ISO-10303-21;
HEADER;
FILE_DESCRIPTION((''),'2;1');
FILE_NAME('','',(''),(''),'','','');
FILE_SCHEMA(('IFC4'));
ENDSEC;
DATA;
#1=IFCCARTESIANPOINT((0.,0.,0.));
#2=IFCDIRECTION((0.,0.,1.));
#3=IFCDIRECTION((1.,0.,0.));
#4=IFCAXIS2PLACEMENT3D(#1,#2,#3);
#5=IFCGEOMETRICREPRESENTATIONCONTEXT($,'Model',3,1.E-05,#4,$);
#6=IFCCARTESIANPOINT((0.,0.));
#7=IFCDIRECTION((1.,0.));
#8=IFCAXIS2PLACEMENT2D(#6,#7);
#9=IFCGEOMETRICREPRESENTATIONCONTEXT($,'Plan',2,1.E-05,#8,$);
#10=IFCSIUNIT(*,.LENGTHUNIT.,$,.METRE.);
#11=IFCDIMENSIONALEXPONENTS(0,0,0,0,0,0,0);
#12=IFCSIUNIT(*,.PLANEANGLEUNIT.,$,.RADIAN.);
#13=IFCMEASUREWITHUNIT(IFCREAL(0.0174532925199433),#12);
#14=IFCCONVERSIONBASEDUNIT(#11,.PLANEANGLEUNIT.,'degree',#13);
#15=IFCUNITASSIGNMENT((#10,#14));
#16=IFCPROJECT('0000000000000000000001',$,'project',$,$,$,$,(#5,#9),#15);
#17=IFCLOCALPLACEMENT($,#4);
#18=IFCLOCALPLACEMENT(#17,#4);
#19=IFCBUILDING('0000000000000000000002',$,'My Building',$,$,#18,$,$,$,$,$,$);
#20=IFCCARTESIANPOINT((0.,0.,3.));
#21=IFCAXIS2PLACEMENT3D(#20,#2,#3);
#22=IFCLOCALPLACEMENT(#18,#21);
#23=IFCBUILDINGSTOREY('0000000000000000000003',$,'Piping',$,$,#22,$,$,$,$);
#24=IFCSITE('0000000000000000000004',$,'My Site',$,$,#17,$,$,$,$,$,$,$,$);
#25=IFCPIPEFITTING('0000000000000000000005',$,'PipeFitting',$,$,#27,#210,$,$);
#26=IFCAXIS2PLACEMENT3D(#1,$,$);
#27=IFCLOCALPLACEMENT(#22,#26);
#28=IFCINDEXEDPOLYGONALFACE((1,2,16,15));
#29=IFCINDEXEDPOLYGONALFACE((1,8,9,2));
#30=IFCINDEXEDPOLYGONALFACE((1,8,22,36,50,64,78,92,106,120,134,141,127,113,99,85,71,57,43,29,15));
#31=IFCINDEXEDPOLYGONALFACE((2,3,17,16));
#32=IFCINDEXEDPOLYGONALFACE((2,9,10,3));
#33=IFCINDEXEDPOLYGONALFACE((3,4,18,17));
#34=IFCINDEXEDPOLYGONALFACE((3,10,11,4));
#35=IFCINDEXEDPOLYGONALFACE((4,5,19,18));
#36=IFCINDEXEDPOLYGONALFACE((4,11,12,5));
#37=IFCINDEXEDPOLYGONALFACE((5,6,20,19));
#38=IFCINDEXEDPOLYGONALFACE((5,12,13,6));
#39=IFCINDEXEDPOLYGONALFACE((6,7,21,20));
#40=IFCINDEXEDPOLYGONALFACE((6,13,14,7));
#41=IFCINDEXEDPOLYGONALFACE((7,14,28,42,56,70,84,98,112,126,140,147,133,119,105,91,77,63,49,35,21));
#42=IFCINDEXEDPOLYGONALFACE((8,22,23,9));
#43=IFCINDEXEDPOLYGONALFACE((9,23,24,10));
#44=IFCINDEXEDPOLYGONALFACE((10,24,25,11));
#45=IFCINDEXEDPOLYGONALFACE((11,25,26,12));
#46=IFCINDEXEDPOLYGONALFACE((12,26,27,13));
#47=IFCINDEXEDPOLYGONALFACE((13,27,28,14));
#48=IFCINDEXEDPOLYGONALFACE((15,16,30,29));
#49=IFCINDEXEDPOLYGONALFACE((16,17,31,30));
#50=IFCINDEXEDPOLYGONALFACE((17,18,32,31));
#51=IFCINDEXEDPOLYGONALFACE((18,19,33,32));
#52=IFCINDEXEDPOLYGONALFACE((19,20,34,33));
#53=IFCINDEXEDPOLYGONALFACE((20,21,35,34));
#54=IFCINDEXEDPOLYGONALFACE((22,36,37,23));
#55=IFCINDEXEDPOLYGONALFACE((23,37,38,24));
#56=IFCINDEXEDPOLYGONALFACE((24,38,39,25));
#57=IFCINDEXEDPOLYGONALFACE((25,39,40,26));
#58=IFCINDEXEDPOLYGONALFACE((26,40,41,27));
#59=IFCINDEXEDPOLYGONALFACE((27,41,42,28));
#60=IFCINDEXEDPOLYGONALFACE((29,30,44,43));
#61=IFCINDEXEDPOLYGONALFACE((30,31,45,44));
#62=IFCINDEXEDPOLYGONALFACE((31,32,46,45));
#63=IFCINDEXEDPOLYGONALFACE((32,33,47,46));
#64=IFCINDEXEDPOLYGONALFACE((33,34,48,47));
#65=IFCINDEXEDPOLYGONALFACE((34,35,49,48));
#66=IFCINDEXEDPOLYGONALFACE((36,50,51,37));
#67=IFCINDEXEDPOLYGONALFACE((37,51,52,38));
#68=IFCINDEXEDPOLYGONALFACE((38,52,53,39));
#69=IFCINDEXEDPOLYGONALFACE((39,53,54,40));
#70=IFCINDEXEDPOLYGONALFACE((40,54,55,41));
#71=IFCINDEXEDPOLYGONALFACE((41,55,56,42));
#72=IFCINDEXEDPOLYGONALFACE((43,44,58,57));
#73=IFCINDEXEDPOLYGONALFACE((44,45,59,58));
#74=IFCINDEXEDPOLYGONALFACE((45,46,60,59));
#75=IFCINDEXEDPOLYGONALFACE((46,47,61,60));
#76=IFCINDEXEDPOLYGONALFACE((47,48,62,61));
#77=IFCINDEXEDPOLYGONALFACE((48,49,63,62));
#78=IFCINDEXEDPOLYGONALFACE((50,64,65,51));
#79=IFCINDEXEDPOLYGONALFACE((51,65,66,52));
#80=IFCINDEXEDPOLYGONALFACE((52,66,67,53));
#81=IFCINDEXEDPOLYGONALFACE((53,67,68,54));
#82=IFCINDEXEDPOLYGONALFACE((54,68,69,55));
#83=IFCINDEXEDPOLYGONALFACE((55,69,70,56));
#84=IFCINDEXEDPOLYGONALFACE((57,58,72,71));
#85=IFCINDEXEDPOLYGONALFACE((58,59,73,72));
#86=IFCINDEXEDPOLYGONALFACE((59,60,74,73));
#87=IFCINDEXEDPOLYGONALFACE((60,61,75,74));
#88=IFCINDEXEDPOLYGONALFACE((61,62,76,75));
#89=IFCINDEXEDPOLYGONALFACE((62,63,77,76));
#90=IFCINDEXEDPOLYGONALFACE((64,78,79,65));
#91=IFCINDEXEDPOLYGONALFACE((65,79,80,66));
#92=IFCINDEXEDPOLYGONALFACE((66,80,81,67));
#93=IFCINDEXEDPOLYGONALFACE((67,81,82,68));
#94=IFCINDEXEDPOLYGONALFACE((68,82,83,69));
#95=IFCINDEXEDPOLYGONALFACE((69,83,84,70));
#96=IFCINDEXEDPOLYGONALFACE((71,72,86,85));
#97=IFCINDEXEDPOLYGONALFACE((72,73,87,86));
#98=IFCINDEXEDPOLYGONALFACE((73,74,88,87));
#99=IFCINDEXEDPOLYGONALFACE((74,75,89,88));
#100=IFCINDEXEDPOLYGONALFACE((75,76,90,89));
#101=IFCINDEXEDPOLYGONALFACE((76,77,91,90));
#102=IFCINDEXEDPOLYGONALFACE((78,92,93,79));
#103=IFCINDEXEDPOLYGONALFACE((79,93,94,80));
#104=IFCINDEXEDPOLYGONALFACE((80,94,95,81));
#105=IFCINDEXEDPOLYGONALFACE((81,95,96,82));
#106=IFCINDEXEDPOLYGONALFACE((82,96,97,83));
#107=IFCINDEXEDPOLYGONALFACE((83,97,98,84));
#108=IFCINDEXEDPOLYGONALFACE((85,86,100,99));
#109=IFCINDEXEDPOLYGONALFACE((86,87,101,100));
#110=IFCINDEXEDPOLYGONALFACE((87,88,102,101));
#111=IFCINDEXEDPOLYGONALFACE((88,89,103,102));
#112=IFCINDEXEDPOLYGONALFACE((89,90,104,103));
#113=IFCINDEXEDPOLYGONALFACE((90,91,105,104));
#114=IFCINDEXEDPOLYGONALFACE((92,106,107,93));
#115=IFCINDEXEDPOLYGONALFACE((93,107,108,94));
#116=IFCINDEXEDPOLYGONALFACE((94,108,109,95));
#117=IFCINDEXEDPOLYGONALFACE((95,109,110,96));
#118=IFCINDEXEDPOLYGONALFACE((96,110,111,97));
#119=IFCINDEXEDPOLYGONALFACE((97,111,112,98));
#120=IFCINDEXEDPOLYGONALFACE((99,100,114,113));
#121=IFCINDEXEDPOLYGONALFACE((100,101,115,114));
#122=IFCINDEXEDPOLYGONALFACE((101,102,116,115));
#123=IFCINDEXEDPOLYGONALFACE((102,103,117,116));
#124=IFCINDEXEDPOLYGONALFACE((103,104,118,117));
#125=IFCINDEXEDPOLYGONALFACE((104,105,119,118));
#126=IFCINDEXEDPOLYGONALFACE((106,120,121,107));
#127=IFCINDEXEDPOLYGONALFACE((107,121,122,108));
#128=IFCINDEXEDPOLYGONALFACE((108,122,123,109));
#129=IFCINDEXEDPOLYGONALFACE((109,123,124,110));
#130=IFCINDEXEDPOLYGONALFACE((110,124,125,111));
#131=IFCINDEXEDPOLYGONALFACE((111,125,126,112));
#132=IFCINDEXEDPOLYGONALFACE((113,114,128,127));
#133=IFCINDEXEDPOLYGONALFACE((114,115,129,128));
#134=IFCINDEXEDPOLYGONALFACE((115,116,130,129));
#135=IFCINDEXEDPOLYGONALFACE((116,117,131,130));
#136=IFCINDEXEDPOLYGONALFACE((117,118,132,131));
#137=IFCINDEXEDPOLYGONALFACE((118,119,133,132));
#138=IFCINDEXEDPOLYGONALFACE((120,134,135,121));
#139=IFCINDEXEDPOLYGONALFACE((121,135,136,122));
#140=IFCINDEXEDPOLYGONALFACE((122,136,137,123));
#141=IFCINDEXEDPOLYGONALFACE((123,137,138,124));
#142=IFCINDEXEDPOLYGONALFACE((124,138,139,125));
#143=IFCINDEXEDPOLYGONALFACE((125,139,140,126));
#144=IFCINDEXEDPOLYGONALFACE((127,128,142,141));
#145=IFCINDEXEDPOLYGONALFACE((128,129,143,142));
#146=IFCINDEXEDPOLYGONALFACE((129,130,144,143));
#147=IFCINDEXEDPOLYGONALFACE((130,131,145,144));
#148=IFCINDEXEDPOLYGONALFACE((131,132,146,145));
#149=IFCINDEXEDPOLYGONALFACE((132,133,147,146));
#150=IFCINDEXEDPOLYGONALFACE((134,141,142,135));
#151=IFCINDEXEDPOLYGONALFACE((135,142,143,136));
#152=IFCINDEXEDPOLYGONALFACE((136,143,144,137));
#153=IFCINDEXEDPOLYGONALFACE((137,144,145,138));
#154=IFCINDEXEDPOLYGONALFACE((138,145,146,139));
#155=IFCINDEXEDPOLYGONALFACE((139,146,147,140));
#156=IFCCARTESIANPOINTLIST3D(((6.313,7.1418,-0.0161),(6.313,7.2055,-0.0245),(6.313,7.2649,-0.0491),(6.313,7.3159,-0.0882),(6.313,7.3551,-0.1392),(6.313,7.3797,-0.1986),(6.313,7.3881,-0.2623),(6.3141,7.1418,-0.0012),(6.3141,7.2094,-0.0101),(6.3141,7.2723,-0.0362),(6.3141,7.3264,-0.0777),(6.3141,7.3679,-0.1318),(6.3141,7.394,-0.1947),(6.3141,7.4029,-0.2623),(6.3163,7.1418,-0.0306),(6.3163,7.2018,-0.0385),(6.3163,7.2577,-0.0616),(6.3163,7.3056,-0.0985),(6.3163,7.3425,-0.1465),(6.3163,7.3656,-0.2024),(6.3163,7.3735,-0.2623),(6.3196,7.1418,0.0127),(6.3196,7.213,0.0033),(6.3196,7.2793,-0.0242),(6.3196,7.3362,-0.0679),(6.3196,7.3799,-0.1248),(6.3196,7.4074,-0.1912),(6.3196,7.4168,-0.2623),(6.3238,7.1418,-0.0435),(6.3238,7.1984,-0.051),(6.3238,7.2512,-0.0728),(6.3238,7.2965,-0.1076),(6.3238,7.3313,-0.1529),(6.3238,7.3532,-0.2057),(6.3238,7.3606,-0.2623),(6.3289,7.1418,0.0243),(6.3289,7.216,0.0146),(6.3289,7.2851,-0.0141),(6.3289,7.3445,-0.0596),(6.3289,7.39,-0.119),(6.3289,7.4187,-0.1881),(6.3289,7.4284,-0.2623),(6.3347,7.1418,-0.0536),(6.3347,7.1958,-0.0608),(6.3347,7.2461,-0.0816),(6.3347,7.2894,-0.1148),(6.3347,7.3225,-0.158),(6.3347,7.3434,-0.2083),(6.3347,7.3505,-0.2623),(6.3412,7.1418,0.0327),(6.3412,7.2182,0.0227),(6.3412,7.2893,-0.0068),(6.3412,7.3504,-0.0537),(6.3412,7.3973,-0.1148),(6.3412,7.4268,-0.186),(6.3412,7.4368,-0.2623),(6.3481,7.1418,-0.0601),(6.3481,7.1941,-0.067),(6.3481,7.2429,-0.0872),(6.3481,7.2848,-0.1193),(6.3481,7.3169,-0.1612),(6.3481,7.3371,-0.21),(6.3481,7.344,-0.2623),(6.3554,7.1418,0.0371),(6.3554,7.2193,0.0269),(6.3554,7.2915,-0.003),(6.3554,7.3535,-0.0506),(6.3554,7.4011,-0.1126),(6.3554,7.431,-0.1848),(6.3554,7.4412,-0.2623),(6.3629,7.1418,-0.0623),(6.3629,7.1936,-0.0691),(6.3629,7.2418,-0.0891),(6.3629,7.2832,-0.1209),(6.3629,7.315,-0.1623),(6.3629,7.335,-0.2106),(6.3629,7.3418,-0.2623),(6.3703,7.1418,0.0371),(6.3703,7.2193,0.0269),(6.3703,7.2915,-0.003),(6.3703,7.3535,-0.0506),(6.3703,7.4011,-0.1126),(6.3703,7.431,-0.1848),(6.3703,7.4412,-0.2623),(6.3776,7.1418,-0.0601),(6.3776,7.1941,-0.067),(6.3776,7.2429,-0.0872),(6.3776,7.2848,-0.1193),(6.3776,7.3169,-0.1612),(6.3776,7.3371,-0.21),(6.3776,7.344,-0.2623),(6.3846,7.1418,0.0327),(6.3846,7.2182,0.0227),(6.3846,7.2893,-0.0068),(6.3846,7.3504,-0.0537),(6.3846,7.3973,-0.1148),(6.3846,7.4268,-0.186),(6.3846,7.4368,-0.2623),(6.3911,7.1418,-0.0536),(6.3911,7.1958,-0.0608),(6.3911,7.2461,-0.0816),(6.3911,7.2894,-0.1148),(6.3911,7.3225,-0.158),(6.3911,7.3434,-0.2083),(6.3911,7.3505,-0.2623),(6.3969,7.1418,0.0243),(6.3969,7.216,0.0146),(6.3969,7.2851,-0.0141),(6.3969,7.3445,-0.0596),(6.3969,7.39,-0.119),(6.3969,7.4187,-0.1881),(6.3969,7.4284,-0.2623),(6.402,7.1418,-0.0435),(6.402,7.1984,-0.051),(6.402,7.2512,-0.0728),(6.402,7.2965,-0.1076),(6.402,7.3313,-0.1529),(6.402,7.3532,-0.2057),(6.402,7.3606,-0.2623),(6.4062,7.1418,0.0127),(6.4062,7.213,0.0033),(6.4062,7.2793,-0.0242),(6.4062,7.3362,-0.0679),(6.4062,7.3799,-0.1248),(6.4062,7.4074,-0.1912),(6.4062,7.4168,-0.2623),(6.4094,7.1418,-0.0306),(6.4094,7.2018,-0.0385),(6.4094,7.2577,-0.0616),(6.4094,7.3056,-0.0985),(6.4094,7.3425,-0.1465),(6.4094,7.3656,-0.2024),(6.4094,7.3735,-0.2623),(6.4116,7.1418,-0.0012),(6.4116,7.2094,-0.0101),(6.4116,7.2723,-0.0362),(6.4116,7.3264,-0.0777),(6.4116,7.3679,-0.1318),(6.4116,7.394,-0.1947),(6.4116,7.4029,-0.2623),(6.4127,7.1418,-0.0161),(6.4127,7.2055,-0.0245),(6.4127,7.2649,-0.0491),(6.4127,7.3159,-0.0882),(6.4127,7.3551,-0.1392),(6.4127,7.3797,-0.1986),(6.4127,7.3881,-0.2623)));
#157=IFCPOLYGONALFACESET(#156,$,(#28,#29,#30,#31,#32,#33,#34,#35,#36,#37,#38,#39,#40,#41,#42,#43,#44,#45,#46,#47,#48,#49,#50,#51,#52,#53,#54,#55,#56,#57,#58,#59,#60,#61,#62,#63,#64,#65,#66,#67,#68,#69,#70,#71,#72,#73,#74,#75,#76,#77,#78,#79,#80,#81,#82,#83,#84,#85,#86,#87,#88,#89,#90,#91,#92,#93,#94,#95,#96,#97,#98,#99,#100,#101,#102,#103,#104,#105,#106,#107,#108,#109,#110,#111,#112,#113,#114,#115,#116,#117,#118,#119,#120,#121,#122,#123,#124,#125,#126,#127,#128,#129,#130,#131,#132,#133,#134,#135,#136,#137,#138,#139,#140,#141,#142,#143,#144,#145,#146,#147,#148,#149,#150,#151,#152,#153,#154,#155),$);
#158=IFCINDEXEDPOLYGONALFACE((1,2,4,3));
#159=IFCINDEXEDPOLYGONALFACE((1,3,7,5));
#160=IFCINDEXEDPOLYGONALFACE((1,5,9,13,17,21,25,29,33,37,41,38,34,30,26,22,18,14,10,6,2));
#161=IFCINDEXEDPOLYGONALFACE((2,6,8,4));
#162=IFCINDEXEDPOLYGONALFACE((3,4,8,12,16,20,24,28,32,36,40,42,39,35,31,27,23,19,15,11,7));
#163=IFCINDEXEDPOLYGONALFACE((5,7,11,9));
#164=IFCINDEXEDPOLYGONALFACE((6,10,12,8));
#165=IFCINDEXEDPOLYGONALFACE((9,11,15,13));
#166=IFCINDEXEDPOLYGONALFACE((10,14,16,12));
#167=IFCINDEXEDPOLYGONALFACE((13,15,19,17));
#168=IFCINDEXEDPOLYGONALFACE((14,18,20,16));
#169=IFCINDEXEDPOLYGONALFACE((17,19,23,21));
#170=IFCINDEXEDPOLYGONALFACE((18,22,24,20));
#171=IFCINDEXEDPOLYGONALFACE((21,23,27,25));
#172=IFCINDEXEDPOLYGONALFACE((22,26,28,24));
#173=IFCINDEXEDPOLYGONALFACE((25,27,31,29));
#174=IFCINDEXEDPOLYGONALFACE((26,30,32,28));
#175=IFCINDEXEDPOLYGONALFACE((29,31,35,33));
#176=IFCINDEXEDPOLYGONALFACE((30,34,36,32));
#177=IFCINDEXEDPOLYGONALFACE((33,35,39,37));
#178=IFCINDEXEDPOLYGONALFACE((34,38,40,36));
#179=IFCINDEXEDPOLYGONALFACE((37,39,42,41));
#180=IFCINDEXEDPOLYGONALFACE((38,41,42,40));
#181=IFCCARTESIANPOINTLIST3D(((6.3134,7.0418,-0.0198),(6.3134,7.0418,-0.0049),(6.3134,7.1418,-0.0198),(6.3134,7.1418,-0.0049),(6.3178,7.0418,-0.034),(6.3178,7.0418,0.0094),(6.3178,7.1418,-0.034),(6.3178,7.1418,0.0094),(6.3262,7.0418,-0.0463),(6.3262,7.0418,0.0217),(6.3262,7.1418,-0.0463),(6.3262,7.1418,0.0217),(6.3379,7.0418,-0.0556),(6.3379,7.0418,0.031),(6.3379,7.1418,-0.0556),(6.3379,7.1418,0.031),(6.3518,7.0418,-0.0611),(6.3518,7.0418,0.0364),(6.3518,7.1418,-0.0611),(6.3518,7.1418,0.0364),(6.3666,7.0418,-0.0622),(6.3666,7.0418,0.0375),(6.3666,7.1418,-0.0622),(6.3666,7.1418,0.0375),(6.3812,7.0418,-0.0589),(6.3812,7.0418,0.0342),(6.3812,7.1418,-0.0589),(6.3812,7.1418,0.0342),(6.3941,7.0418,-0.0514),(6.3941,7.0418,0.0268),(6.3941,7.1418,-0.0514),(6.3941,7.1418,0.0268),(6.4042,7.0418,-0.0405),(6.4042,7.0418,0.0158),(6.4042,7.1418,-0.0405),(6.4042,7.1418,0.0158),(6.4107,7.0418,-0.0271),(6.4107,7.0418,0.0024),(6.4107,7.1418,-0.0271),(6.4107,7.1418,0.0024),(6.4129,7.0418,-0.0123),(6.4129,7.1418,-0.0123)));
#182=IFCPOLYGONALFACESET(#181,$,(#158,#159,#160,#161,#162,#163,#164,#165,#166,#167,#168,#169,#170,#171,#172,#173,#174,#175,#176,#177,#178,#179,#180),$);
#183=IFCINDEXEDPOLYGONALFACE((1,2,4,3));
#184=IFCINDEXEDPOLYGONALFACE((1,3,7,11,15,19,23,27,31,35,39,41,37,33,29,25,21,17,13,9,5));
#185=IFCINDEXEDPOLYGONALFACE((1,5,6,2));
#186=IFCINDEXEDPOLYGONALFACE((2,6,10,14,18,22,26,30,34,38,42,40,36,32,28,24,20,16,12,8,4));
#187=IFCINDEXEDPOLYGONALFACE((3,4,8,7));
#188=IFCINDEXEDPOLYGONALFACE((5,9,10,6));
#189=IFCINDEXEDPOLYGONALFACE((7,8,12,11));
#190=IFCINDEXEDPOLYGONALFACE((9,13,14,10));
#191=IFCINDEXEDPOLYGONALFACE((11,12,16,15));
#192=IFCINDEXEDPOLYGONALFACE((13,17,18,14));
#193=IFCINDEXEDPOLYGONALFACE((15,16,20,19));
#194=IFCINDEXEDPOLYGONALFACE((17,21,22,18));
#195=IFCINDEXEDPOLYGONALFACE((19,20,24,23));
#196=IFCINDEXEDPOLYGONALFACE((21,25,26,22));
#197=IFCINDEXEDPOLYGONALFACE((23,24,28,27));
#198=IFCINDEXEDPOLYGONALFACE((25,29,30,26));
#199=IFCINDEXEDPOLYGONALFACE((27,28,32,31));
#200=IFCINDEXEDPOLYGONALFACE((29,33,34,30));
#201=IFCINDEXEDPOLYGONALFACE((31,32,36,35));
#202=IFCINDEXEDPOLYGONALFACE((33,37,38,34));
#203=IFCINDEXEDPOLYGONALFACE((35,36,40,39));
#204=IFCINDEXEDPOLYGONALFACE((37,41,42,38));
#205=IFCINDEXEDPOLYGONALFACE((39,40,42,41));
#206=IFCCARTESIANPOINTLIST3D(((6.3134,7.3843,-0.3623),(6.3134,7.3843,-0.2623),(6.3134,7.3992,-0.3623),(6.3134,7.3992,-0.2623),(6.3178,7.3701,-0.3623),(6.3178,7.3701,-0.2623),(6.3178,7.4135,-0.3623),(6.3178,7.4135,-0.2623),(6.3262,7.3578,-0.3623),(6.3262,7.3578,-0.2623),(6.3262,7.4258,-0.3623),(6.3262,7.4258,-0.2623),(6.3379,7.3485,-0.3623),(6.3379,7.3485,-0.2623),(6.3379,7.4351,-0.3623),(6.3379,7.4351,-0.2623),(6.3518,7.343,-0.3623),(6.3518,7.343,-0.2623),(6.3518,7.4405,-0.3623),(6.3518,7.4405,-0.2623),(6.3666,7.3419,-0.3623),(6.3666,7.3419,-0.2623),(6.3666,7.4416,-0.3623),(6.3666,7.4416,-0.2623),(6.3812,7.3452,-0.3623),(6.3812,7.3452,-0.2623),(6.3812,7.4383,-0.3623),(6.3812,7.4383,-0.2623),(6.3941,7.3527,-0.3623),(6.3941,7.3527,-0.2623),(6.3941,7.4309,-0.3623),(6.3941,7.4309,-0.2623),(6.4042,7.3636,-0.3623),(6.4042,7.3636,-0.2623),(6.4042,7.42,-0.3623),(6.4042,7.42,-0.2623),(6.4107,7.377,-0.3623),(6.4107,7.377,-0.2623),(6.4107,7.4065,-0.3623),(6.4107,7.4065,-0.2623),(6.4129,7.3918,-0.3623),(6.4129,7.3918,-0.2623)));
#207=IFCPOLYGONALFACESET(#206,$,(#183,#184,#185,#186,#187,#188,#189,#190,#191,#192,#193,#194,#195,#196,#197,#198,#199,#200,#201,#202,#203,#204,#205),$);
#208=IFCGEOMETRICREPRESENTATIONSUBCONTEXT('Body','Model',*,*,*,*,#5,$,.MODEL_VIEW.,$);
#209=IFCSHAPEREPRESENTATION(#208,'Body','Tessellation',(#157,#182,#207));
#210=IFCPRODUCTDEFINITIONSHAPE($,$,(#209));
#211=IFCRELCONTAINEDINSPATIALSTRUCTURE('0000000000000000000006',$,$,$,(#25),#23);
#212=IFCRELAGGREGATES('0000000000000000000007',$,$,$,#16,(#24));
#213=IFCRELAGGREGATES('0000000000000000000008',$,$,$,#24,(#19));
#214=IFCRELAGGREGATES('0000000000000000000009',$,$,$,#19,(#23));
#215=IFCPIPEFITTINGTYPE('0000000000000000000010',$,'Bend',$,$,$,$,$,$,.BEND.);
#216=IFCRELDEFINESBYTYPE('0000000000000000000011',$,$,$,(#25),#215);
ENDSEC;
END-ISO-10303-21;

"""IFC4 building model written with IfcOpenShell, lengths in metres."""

from ifc_helpers import new_model, entity, si_unit, converted_unit, frame, origin_with_axes, origin_2d_with_axis, place, context, subcontext, project, spatial, circle, extrude, source, transform, mapped, type_object, type_shapes, element, save


model = new_model("IFC4")

# Units and contexts
model_context = context("Model", 3, precision=1e-05, world=origin_with_axes())
plan_context = context("Plan", 2, precision=1e-05, world=origin_2d_with_axis())
body_context = subcontext(model_context, "Body", "Model", "MODEL_VIEW")
ifc_project = project(units=[si_unit("LENGTHUNIT", "METRE"), converted_unit("PLANEANGLEUNIT", "degree", entity("IfcReal", 0.0174532925199433), si_unit("PLANEANGLEUNIT", "RADIAN"), dimensions=[0, 0, 0, 0, 0, 0, 0])], contexts=[model_context, plan_context])

# Site, building, storey
site_placement = place(None, origin_with_axes())
site = spatial("IfcSite", under=ifc_project, at=site_placement, Name="My Site")
building_placement = place(site_placement, origin_with_axes())
building = spatial("IfcBuilding", under=site, at=building_placement, Name="My Building")
storey_placement = place(building_placement, frame((0.0, 0.0, 3.0), z_axis=(0.0, 0.0, 1.0), x_axis=(1.0, 0.0, 0.0)))
storey = spatial("IfcBuildingStorey", under=building, at=storey_placement, Name="Piping")

# Pipe fitting
pipe_fitting_type = type_object("IfcPipeFittingType", Name="Bend", PredefinedType="BEND")
shared_shape = source(origin_with_axes(), body_context, "Body", "SolidModel", [
    entity("IfcSweptDiskSolid", entity("IfcIndexedPolyCurve", entity("IfcCartesianPointList3D", [[0.0, 0.0, -0.1], [0.0, -0.0732, -0.2768], [0.0, -0.25, -0.35]]), [entity("IfcArcIndex", [1, 2, 3])]), 0.05),
    extrude(circle(Radius=0.05), origin_with_axes(), (0.0, 0.0, -1.0), 0.1),
    extrude(circle(Radius=0.05), frame((0.0, -0.25, -0.35), z_axis=(0.0, -1.0, 0.0), x_axis=(1.0, 0.0, 0.0)), (0.0, 0.0, 1.0), 0.1),
])
type_shapes(pipe_fitting_type, [shared_shape])
for number, where, z_axis, x_axis, name in (
    (1, (6.3629, 7.0418, -0.0123), (0.0, -1.0, 0.0), (1.0, 0.0, 0.0), "PipeFitting"),
):
    element("IfcPipeFitting", number, at=place(storey_placement, frame(where, z_axis=z_axis, x_axis=x_axis)), inside=storey, type_object=pipe_fitting_type, Name=name, context=body_context, shape_type="MappedRepresentation", body=[
        mapped(shared_shape, transform((0.0, 0.0, 0.0), x_axis=(1.0, 0.0, 0.0), y_axis=(0.0, 1.0, 0.0), z_axis=(0.0, 0.0, 1.0), scale=1.0)),
    ])

save(model, "model.ifc")
